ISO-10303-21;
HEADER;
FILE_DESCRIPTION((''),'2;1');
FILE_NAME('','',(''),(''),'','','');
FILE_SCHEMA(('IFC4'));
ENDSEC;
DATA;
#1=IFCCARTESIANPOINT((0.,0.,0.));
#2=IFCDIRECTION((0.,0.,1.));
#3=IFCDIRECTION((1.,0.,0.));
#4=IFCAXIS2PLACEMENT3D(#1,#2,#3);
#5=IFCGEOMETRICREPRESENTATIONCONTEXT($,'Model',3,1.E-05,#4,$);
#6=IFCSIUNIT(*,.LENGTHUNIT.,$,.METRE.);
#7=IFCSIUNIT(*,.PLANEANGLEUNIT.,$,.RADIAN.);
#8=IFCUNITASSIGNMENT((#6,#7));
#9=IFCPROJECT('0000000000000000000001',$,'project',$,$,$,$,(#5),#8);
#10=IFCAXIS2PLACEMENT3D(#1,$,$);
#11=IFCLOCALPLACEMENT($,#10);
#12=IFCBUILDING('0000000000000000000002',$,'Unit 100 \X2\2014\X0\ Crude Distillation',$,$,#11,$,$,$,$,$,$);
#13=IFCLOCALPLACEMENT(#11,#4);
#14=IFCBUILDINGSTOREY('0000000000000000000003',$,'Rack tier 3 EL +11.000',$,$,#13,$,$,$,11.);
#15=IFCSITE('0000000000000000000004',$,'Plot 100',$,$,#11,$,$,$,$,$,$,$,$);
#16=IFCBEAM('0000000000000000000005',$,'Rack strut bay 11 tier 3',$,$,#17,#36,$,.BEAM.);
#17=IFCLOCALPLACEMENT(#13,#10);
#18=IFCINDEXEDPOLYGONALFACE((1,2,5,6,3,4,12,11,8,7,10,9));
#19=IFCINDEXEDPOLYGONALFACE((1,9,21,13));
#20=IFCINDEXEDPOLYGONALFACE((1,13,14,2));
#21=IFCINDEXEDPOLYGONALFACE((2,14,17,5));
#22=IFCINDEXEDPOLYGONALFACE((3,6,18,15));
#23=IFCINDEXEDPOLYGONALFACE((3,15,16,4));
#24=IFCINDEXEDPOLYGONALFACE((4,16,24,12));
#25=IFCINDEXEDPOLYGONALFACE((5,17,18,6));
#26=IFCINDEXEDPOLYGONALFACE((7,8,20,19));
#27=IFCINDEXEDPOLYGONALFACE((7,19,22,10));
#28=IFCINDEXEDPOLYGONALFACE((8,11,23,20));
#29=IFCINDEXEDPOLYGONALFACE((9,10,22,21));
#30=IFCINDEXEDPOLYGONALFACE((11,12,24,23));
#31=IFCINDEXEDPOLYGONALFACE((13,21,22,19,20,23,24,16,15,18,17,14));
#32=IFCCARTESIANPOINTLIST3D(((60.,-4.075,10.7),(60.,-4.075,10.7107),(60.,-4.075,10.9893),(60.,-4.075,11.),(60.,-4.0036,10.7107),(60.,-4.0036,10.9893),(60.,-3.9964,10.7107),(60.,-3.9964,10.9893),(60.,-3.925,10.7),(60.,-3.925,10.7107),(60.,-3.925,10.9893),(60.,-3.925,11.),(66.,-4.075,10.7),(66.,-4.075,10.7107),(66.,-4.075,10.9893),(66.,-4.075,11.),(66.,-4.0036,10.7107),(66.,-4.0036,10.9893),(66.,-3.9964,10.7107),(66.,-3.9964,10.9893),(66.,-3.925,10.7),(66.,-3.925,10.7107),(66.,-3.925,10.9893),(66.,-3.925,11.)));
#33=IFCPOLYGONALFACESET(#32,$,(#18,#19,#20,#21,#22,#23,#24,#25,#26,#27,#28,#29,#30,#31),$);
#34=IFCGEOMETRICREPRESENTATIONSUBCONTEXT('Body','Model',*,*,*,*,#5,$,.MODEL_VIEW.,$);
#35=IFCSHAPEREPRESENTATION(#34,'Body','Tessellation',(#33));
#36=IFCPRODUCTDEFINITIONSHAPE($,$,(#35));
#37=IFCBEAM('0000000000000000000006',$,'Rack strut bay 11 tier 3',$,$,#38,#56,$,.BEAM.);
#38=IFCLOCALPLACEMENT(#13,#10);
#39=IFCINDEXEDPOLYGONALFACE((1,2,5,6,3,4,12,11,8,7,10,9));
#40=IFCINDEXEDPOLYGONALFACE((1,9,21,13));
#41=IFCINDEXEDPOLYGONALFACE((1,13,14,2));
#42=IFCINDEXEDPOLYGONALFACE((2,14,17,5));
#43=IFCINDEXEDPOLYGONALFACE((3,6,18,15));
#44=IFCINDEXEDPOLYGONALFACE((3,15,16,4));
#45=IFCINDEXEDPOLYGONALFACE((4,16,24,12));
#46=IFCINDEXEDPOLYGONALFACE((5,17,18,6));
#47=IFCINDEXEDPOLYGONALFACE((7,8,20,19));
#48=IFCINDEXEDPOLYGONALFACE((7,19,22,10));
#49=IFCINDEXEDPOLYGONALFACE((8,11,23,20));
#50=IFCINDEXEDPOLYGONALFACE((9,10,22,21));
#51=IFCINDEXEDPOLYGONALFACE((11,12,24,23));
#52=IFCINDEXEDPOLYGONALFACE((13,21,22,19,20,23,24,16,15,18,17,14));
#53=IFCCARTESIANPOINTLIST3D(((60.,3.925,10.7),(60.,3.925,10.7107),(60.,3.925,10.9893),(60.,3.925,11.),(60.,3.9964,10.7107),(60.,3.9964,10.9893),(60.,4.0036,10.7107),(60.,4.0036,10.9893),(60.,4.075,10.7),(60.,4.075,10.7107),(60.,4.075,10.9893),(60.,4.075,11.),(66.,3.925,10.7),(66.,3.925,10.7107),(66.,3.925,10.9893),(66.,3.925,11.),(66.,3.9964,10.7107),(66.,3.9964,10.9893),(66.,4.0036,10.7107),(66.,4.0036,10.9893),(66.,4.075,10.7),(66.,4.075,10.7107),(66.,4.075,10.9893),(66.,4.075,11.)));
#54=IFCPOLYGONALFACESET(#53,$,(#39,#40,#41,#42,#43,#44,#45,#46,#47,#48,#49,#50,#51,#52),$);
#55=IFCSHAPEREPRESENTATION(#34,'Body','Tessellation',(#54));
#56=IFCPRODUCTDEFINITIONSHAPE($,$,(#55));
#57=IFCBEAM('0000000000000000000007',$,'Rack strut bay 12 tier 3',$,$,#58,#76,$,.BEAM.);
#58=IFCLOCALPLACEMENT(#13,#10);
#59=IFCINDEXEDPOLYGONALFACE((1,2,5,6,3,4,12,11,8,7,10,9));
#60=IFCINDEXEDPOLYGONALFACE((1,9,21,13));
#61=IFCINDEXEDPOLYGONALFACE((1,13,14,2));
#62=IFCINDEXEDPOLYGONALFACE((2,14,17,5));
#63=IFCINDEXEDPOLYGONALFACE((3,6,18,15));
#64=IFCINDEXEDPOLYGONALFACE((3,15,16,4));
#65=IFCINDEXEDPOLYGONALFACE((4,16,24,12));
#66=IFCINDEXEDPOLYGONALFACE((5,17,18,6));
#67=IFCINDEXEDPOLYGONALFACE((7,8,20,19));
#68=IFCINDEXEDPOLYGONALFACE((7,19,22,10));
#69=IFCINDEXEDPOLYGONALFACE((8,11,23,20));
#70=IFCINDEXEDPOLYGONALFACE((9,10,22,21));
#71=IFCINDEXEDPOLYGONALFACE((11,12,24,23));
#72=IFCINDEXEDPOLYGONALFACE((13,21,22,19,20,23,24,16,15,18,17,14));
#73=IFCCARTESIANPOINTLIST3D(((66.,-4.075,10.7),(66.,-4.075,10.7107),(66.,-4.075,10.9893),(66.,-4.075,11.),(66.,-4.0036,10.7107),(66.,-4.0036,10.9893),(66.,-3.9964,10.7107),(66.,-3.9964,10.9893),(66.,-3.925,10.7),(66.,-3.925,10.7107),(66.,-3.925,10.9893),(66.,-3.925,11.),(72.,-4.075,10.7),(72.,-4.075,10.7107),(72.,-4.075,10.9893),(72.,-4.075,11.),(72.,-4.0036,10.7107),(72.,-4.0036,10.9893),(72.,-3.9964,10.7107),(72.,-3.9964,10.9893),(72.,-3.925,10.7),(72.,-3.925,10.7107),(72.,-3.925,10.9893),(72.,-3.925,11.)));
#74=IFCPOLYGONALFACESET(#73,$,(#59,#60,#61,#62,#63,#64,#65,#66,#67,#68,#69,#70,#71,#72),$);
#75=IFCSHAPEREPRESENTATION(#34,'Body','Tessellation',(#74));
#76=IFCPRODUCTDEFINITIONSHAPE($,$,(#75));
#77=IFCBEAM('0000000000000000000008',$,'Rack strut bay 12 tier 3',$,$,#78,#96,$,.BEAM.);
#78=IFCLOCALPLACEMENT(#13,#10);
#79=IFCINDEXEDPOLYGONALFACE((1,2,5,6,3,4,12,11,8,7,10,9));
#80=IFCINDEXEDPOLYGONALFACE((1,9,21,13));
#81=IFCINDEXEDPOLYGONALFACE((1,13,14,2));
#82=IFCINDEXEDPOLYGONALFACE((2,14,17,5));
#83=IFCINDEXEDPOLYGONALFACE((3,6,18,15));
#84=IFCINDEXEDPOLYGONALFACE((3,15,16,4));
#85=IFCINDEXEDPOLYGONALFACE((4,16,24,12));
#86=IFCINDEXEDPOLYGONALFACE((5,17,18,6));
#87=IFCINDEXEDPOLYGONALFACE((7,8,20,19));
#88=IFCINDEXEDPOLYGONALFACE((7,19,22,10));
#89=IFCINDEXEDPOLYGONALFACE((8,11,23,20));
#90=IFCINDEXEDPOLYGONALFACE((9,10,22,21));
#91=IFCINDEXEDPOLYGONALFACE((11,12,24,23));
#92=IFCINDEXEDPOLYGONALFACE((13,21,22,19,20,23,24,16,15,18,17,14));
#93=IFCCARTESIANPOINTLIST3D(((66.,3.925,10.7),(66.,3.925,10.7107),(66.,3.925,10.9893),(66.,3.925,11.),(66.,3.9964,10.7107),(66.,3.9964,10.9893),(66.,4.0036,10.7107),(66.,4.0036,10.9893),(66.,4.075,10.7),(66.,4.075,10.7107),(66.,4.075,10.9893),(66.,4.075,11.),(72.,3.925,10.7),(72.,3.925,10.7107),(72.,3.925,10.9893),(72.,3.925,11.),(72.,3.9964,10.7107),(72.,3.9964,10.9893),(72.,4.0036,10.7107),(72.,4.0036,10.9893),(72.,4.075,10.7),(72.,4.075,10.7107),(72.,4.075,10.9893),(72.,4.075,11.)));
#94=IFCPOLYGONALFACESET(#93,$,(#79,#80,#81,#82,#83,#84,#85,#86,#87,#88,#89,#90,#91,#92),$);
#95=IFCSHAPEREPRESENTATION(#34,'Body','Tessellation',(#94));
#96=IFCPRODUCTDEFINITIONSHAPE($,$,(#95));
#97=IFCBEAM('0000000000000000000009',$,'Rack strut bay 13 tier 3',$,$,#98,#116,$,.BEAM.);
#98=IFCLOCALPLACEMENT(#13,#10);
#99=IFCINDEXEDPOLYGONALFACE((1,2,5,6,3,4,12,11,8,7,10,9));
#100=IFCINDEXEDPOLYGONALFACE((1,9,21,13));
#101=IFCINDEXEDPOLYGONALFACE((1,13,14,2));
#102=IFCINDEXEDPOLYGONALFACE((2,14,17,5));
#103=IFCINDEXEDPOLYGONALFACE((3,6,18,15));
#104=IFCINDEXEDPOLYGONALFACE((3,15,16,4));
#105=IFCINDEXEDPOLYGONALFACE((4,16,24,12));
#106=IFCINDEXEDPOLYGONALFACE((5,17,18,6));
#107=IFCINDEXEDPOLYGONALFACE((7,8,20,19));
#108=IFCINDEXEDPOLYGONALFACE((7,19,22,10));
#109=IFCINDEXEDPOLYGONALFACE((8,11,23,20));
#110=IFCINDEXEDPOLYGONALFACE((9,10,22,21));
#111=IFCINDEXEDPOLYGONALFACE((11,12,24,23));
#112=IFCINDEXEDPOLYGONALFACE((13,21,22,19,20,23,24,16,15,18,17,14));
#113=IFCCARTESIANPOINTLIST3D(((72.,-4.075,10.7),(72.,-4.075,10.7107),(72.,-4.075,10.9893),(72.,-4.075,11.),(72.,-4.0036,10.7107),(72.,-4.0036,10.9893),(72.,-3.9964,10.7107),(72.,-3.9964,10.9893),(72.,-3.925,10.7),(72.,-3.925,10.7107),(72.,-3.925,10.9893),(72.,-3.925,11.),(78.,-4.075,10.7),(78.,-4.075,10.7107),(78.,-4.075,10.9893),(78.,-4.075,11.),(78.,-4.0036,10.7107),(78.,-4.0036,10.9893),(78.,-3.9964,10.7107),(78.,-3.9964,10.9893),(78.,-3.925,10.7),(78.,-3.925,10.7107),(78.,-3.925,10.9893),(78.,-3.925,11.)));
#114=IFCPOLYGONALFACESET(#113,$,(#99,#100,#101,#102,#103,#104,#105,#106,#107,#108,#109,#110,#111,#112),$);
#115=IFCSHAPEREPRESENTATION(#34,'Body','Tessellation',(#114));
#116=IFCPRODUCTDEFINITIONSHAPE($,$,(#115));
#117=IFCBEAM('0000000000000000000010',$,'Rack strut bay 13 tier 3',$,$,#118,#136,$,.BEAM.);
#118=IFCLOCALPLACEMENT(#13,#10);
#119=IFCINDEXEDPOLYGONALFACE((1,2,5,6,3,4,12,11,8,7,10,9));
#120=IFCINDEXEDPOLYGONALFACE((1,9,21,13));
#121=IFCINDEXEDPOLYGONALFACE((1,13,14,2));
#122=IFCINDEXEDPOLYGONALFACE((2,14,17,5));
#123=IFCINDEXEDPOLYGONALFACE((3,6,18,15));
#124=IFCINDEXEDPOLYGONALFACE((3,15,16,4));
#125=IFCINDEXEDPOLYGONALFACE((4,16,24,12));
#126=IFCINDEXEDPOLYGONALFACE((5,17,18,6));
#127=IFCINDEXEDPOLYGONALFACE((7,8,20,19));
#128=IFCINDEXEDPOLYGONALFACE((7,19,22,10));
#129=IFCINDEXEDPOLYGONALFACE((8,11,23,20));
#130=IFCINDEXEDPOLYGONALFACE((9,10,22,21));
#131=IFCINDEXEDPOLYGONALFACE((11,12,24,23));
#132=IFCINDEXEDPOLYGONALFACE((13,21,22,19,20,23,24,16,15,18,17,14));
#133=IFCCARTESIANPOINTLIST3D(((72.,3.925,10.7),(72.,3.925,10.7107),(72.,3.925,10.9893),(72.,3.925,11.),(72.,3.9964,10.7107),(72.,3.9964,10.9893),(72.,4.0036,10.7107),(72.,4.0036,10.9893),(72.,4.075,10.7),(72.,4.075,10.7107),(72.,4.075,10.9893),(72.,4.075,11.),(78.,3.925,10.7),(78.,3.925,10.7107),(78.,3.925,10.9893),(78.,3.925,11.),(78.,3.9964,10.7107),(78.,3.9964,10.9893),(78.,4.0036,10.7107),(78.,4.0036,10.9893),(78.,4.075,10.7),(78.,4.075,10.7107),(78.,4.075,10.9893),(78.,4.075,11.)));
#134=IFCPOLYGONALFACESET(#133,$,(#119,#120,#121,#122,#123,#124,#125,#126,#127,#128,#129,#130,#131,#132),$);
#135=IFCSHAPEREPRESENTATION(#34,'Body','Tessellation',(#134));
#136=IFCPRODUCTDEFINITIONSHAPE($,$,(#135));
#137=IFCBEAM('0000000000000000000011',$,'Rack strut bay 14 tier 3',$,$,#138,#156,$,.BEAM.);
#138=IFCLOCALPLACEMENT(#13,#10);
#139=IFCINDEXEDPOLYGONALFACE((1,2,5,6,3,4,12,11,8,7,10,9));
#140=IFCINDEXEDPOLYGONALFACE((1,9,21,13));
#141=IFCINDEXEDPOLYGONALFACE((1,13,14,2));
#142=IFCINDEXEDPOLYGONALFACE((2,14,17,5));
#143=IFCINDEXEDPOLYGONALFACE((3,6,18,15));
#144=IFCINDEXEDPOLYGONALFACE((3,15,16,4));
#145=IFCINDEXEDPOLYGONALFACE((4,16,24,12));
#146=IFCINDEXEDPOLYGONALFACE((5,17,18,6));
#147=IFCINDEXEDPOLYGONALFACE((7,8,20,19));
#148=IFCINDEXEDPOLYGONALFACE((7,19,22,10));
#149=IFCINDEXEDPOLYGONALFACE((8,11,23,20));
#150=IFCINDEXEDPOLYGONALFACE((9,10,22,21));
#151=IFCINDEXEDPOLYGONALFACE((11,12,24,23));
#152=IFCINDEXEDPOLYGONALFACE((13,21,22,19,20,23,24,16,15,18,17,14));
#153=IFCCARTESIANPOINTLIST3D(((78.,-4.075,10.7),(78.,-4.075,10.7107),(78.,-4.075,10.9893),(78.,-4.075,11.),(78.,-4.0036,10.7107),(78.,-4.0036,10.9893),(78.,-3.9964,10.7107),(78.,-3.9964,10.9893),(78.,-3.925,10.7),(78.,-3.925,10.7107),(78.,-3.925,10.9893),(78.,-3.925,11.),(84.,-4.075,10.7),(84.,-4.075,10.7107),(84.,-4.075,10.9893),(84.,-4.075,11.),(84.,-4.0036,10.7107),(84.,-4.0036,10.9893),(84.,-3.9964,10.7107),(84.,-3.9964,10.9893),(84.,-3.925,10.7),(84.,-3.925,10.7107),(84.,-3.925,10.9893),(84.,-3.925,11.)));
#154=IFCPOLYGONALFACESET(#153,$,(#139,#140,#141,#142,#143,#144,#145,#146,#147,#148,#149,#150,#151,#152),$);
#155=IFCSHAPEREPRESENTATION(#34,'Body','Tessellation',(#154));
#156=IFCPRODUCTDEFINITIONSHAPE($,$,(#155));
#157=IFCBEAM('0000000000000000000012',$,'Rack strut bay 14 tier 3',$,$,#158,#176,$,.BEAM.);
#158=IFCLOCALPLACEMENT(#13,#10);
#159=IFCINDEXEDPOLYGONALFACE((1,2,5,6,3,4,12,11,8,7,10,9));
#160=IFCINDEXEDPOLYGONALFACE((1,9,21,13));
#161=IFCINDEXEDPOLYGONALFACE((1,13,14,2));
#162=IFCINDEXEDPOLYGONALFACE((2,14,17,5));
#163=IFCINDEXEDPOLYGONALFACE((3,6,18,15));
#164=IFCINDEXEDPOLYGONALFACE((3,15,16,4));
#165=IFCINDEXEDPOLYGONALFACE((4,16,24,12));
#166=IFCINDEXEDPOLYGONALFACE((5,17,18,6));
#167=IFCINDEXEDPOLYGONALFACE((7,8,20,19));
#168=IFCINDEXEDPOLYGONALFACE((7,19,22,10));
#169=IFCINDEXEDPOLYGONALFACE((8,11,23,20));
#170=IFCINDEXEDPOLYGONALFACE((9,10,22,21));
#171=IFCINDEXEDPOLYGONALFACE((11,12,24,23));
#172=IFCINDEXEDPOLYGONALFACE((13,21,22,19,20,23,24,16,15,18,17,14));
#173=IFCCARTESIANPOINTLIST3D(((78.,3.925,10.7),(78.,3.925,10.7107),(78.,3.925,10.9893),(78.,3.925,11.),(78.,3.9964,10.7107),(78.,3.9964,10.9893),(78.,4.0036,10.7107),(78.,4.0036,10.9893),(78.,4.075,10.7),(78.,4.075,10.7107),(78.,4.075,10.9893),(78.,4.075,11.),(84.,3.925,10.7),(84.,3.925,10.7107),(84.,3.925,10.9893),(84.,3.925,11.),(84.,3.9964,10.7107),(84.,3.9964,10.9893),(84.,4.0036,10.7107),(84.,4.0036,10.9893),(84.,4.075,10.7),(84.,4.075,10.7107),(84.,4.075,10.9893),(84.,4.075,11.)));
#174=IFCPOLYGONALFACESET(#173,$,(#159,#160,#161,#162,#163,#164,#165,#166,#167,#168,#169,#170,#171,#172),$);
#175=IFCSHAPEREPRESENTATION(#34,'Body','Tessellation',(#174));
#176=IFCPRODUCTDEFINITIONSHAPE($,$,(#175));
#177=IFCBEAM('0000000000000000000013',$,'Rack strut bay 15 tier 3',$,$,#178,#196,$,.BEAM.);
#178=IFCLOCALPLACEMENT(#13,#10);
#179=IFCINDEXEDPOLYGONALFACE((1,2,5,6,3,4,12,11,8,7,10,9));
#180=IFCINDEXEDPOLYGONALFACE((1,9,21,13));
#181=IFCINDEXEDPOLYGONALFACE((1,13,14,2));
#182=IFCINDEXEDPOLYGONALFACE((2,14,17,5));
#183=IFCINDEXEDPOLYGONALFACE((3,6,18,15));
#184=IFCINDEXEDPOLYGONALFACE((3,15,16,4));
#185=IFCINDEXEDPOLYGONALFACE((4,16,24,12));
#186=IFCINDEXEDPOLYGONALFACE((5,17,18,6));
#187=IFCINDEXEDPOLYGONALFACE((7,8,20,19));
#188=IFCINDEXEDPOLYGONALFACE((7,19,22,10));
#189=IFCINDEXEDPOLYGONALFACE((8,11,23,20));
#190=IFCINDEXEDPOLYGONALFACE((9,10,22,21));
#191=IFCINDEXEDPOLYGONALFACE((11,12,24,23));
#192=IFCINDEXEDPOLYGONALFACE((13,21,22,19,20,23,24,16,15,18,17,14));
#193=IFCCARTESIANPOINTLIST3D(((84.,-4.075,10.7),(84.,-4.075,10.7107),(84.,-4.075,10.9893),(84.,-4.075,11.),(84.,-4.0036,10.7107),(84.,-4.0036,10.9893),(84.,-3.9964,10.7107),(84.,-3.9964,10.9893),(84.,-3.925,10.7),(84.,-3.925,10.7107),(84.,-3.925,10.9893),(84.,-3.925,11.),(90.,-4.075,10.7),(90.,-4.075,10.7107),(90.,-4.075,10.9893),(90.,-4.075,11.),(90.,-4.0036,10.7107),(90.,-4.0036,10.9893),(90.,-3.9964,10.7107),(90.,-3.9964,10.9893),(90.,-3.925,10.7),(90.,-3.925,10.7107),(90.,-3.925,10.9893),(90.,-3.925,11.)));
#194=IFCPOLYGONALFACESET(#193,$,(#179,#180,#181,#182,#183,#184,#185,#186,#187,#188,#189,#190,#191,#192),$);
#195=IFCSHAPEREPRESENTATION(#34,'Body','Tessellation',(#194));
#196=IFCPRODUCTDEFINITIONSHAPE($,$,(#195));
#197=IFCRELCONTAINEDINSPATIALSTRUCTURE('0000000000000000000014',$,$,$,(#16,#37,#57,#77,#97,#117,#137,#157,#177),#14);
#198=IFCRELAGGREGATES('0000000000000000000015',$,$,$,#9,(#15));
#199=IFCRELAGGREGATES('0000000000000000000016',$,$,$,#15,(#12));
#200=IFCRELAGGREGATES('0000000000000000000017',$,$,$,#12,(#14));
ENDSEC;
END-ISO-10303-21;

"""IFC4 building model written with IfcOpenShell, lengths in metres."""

from ifc_helpers import new_model, si_unit, frame, origin, origin_with_axes, origin_2d, place, context, subcontext, project, spatial, i_section, extrude, element, save


model = new_model("IFC4")

# Units and contexts
model_context = context("Model", 3, precision=1e-05, world=origin_with_axes())
body_context = subcontext(model_context, "Body", "Model", "MODEL_VIEW")
ifc_project = project(units=[si_unit("LENGTHUNIT", "METRE"), si_unit("PLANEANGLEUNIT", "RADIAN")], contexts=[model_context])

# Site, building, storey
placement = place(None, origin())
site = spatial("IfcSite", under=ifc_project, at=placement, Name="Plot 100")
building = spatial("IfcBuilding", under=site, at=placement, Name="Unit 100 — Crude Distillation")
storey_placement = place(placement, origin_with_axes())
storey = spatial("IfcBuildingStorey", under=building, at=storey_placement, Name="Rack tier 3 EL +11.000", Elevation=11.0)

# Beams
beam_1_placement = place(storey_placement, origin_with_axes())
element("IfcBeam", 1, at=beam_1_placement, inside=storey, Name="Rack strut bay 11 tier 3", PredefinedType="BEAM", context=body_context, shape_type="SweptSolid", body=[
    extrude(i_section(OverallWidth=0.15, OverallDepth=0.3, WebThickness=0.0071, FlangeThickness=0.0107, at=origin_2d()), frame((60.0, -4.0, 10.85), z_axis=(1.0, 0.0, 0.0), x_axis=(0.0, 1.0, 0.0)), (0.0, 0.0, 1.0), 6.0),
])
beam_2_placement = place(storey_placement, origin_with_axes())
element("IfcBeam", 2, at=beam_2_placement, inside=storey, Name="Rack strut bay 11 tier 3", PredefinedType="BEAM", context=body_context, shape_type="SweptSolid", body=[
    extrude(i_section(OverallWidth=0.15, OverallDepth=0.3, WebThickness=0.0071, FlangeThickness=0.0107, at=origin_2d()), frame((60.0, 4.0, 10.85), z_axis=(1.0, 0.0, 0.0), x_axis=(0.0, 1.0, 0.0)), (0.0, 0.0, 1.0), 6.0),
])
beam_3_placement = place(storey_placement, origin_with_axes())
element("IfcBeam", 3, at=beam_3_placement, inside=storey, Name="Rack strut bay 12 tier 3", PredefinedType="BEAM", context=body_context, shape_type="SweptSolid", body=[
    extrude(i_section(OverallWidth=0.15, OverallDepth=0.3, WebThickness=0.0071, FlangeThickness=0.0107, at=origin_2d()), frame((66.0, -4.0, 10.85), z_axis=(1.0, 0.0, 0.0), x_axis=(0.0, 1.0, 0.0)), (0.0, 0.0, 1.0), 6.0),
])
beam_4_placement = place(storey_placement, origin_with_axes())
element("IfcBeam", 4, at=beam_4_placement, inside=storey, Name="Rack strut bay 12 tier 3", PredefinedType="BEAM", context=body_context, shape_type="SweptSolid", body=[
    extrude(i_section(OverallWidth=0.15, OverallDepth=0.3, WebThickness=0.0071, FlangeThickness=0.0107, at=origin_2d()), frame((66.0, 4.0, 10.85), z_axis=(1.0, 0.0, 0.0), x_axis=(0.0, 1.0, 0.0)), (0.0, 0.0, 1.0), 6.0),
])
beam_5_placement = place(storey_placement, origin_with_axes())
element("IfcBeam", 5, at=beam_5_placement, inside=storey, Name="Rack strut bay 13 tier 3", PredefinedType="BEAM", context=body_context, shape_type="SweptSolid", body=[
    extrude(i_section(OverallWidth=0.15, OverallDepth=0.3, WebThickness=0.0071, FlangeThickness=0.0107, at=origin_2d()), frame((72.0, -4.0, 10.85), z_axis=(1.0, 0.0, 0.0), x_axis=(0.0, 1.0, 0.0)), (0.0, 0.0, 1.0), 6.0),
])
beam_6_placement = place(storey_placement, origin_with_axes())
element("IfcBeam", 6, at=beam_6_placement, inside=storey, Name="Rack strut bay 13 tier 3", PredefinedType="BEAM", context=body_context, shape_type="SweptSolid", body=[
    extrude(i_section(OverallWidth=0.15, OverallDepth=0.3, WebThickness=0.0071, FlangeThickness=0.0107, at=origin_2d()), frame((72.0, 4.0, 10.85), z_axis=(1.0, 0.0, 0.0), x_axis=(0.0, 1.0, 0.0)), (0.0, 0.0, 1.0), 6.0),
])
beam_7_placement = place(storey_placement, origin_with_axes())
element("IfcBeam", 7, at=beam_7_placement, inside=storey, Name="Rack strut bay 14 tier 3", PredefinedType="BEAM", context=body_context, shape_type="SweptSolid", body=[
    extrude(i_section(OverallWidth=0.15, OverallDepth=0.3, WebThickness=0.0071, FlangeThickness=0.0107, at=origin_2d()), frame((78.0, -4.0, 10.85), z_axis=(1.0, 0.0, 0.0), x_axis=(0.0, 1.0, 0.0)), (0.0, 0.0, 1.0), 6.0),
])
beam_8_placement = place(storey_placement, origin_with_axes())
element("IfcBeam", 8, at=beam_8_placement, inside=storey, Name="Rack strut bay 14 tier 3", PredefinedType="BEAM", context=body_context, shape_type="SweptSolid", body=[
    extrude(i_section(OverallWidth=0.15, OverallDepth=0.3, WebThickness=0.0071, FlangeThickness=0.0107, at=origin_2d()), frame((78.0, 4.0, 10.85), z_axis=(1.0, 0.0, 0.0), x_axis=(0.0, 1.0, 0.0)), (0.0, 0.0, 1.0), 6.0),
])
beam_9_placement = place(storey_placement, origin_with_axes())
element("IfcBeam", 9, at=beam_9_placement, inside=storey, Name="Rack strut bay 15 tier 3", PredefinedType="BEAM", context=body_context, shape_type="SweptSolid", body=[
    extrude(i_section(OverallWidth=0.15, OverallDepth=0.3, WebThickness=0.0071, FlangeThickness=0.0107, at=origin_2d()), frame((84.0, -4.0, 10.85), z_axis=(1.0, 0.0, 0.0), x_axis=(0.0, 1.0, 0.0)), (0.0, 0.0, 1.0), 6.0),
])

save(model, "model.ifc")
